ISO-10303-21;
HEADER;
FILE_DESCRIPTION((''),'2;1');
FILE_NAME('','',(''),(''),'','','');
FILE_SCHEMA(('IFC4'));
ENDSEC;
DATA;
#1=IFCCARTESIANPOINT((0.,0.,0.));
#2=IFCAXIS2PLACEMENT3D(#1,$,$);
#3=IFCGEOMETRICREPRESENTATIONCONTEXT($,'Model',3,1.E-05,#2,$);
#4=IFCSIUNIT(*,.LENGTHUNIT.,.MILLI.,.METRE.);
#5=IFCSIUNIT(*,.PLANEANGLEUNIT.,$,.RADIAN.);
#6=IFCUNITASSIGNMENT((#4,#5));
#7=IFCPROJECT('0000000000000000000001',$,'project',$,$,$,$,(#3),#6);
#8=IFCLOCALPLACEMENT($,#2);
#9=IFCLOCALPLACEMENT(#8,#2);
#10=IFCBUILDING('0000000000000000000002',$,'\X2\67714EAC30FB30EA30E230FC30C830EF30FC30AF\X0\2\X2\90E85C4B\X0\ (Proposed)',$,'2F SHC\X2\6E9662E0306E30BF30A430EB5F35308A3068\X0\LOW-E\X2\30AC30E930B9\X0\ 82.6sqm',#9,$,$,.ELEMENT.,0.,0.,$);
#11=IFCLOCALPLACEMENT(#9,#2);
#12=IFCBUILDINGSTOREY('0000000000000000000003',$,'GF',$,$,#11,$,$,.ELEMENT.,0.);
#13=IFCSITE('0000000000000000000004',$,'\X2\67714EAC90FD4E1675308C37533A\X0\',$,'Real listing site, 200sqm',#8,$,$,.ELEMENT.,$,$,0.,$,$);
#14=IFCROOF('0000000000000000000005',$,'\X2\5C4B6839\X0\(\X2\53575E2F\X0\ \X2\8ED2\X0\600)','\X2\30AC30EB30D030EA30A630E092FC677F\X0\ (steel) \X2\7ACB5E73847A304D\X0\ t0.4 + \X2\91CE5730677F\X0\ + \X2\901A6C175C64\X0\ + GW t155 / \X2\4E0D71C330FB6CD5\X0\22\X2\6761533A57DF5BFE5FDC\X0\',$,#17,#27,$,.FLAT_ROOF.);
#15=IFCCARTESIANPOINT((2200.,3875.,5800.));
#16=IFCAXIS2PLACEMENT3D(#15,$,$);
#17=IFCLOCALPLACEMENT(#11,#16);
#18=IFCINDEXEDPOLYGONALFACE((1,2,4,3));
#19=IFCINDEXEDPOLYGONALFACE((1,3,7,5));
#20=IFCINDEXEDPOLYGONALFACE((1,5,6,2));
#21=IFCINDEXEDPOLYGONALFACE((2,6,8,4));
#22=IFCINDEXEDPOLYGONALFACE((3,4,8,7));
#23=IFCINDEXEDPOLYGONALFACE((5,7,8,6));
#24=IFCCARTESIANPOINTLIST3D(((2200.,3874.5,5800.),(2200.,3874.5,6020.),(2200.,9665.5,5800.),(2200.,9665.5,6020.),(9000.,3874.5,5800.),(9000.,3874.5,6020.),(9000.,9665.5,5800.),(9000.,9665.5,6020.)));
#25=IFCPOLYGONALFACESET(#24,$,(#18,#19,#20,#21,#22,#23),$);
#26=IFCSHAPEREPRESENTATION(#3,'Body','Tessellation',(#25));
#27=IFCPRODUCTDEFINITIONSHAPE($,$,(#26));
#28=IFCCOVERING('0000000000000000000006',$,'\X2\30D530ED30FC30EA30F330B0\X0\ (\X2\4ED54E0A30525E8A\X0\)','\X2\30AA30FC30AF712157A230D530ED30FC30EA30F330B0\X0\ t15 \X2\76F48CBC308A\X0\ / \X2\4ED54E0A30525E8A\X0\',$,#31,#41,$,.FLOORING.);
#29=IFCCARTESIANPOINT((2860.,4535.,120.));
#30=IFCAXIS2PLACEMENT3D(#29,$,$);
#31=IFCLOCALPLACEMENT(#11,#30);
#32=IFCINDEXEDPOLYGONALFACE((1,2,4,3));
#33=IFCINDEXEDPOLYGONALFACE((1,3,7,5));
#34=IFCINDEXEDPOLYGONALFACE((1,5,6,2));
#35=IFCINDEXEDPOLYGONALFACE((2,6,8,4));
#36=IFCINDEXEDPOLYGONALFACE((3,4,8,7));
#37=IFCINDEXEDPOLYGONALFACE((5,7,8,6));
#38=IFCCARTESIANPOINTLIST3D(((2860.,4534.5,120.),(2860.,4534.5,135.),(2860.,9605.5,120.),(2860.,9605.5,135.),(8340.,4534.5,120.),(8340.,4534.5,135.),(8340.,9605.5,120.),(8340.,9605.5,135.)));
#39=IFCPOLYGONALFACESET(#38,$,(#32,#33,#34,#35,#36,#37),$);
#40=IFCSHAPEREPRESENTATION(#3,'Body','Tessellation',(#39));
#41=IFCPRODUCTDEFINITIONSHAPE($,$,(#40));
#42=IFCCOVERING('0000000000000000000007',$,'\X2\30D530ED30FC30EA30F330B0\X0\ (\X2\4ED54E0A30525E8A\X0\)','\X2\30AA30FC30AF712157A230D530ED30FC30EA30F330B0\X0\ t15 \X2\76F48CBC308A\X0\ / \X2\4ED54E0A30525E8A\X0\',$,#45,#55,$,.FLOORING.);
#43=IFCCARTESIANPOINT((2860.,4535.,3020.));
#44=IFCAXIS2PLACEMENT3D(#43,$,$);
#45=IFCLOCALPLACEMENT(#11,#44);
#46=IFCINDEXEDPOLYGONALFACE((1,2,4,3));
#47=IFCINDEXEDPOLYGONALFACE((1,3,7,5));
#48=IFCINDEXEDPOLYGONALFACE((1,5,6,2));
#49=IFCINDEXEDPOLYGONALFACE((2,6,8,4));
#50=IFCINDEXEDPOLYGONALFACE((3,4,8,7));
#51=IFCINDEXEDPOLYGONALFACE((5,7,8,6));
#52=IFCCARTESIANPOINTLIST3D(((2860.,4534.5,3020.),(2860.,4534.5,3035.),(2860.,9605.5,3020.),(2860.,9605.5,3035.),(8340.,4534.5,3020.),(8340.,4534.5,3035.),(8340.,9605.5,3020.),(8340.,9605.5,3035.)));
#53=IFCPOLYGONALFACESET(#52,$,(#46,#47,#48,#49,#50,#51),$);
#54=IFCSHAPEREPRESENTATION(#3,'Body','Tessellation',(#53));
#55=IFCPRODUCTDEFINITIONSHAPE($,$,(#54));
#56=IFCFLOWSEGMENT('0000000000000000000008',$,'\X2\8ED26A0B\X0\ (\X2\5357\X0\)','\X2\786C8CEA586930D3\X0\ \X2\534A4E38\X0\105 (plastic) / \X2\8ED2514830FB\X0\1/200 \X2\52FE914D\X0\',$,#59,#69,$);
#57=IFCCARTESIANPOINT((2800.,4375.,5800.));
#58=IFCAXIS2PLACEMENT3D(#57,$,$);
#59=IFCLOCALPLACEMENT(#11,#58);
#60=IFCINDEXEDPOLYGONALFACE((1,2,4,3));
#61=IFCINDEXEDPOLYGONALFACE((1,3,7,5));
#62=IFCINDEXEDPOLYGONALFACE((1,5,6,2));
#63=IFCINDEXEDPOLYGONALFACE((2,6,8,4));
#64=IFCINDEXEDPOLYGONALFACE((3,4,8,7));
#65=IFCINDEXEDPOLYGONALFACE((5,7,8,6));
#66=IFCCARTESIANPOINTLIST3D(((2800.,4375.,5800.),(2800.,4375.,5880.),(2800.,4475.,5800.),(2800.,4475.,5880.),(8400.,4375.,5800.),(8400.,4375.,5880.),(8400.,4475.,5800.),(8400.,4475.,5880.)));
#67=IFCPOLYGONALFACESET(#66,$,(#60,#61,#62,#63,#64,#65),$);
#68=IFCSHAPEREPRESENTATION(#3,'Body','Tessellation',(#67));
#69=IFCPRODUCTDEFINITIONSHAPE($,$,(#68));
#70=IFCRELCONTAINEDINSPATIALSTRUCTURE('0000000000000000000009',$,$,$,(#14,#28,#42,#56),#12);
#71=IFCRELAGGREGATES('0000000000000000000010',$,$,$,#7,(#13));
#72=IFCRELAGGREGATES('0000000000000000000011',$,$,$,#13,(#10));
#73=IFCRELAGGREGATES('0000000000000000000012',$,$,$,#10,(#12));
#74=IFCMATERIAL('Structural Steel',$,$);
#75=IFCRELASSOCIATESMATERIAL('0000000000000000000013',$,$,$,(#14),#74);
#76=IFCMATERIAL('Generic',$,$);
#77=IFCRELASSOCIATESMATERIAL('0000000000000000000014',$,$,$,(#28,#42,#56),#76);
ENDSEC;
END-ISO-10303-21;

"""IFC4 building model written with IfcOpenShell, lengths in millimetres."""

from ifc_helpers import new_model, si_unit, frame, frame_2d, origin, place, context, project, spatial, rectangle, extrude, material, element, save


model = new_model("IFC4")

# Units and contexts
model_context = context("Model", 3, precision=1e-05, world=origin())
ifc_project = project(units=[si_unit("LENGTHUNIT", "METRE", prefix="MILLI"), si_unit("PLANEANGLEUNIT", "RADIAN")], contexts=[model_context])

# Site, building, storey
site_placement = place(None, origin())
site = spatial("IfcSite", under=ifc_project, at=site_placement, Name="東京都世田谷区", ObjectType="Real listing site, 200sqm", CompositionType="ELEMENT", RefElevation=0.0)
building_placement = place(site_placement, origin())
building = spatial("IfcBuilding", under=site, at=building_placement, Name="東京・リモートワーク2部屋 (Proposed)", ObjectType="2F SHC準拠のタイル張りとLOW-Eガラス 82.6sqm", CompositionType="ELEMENT", ElevationOfRefHeight=0.0, ElevationOfTerrain=0.0)
storey_placement = place(building_placement, origin())
storey = spatial("IfcBuildingStorey", under=building, at=storey_placement, Name="GF", CompositionType="ELEMENT", Elevation=0.0)

# Roof
ifc_material_1 = material(Name="Structural Steel")
for number, where, name in (
    (1, (2200.0, 3875.0, 5800.0), "屋根(南帯 軒600)"),
):
    element("IfcRoof", number, at=place(storey_placement, frame(where)), inside=storey, material=ifc_material_1, Name=name, Description="ガルバリウム鋼板 (steel) 立平葺き t0.4 + 野地板 + 通気層 + GW t155 / 不燃・法22条区域対応", PredefinedType="FLAT_ROOF", context=model_context, shape_type="SweptSolid", body=[
        extrude(rectangle(XDim=6800.0, YDim=5791.0, at=frame_2d((3400.0, 2895.0))), frame((2200.0, 3875.0, 5800.0)), (0.0, 0.0, 1.0), 220.0),
    ])

# Coverings
ifc_material_2 = material(Name="Generic")
covering_1_placement = place(storey_placement, frame((2860.0, 4535.0, 120.0)))
element("IfcCovering", 2, at=covering_1_placement, inside=storey, material=ifc_material_2, Name="フローリング (仕上げ床)", Description="オーク無垢フローリング t15 直貼り / 仕上げ床", PredefinedType="FLOORING", context=model_context, shape_type="SweptSolid", body=[
    extrude(rectangle(XDim=5480.0, YDim=5071.0, at=frame_2d((2740.0, 2535.0))), frame((2860.0, 4535.0, 120.0)), (0.0, 0.0, 1.0), 15.0),
])
covering_2_placement = place(storey_placement, frame((2860.0, 4535.0, 3020.0)))
element("IfcCovering", 3, at=covering_2_placement, inside=storey, material=ifc_material_2, Name="フローリング (仕上げ床)", Description="オーク無垢フローリング t15 直貼り / 仕上げ床", PredefinedType="FLOORING", context=model_context, shape_type="SweptSolid", body=[
    extrude(rectangle(XDim=5480.0, YDim=5071.0, at=frame_2d((2740.0, 2535.0))), frame((2860.0, 4535.0, 3020.0)), (0.0, 0.0, 1.0), 15.0),
])

# Flow segment
flow_segment_placement = place(storey_placement, frame((2800.0, 4375.0, 5800.0)))
element("IfcFlowSegment", 4, at=flow_segment_placement, inside=storey, material=ifc_material_2, Name="軒樋 (南)", Description="硬質塩ビ 半丸105 (plastic) / 軒先・1/200 勾配", context=model_context, shape_type="SweptSolid", body=[
    extrude(rectangle(XDim=5600.0, YDim=100.0, at=frame_2d((2800.0, 50.0))), frame((2800.0, 4375.0, 5800.0)), (0.0, 0.0, 1.0), 80.0),
])

save(model, "model.ifc")
